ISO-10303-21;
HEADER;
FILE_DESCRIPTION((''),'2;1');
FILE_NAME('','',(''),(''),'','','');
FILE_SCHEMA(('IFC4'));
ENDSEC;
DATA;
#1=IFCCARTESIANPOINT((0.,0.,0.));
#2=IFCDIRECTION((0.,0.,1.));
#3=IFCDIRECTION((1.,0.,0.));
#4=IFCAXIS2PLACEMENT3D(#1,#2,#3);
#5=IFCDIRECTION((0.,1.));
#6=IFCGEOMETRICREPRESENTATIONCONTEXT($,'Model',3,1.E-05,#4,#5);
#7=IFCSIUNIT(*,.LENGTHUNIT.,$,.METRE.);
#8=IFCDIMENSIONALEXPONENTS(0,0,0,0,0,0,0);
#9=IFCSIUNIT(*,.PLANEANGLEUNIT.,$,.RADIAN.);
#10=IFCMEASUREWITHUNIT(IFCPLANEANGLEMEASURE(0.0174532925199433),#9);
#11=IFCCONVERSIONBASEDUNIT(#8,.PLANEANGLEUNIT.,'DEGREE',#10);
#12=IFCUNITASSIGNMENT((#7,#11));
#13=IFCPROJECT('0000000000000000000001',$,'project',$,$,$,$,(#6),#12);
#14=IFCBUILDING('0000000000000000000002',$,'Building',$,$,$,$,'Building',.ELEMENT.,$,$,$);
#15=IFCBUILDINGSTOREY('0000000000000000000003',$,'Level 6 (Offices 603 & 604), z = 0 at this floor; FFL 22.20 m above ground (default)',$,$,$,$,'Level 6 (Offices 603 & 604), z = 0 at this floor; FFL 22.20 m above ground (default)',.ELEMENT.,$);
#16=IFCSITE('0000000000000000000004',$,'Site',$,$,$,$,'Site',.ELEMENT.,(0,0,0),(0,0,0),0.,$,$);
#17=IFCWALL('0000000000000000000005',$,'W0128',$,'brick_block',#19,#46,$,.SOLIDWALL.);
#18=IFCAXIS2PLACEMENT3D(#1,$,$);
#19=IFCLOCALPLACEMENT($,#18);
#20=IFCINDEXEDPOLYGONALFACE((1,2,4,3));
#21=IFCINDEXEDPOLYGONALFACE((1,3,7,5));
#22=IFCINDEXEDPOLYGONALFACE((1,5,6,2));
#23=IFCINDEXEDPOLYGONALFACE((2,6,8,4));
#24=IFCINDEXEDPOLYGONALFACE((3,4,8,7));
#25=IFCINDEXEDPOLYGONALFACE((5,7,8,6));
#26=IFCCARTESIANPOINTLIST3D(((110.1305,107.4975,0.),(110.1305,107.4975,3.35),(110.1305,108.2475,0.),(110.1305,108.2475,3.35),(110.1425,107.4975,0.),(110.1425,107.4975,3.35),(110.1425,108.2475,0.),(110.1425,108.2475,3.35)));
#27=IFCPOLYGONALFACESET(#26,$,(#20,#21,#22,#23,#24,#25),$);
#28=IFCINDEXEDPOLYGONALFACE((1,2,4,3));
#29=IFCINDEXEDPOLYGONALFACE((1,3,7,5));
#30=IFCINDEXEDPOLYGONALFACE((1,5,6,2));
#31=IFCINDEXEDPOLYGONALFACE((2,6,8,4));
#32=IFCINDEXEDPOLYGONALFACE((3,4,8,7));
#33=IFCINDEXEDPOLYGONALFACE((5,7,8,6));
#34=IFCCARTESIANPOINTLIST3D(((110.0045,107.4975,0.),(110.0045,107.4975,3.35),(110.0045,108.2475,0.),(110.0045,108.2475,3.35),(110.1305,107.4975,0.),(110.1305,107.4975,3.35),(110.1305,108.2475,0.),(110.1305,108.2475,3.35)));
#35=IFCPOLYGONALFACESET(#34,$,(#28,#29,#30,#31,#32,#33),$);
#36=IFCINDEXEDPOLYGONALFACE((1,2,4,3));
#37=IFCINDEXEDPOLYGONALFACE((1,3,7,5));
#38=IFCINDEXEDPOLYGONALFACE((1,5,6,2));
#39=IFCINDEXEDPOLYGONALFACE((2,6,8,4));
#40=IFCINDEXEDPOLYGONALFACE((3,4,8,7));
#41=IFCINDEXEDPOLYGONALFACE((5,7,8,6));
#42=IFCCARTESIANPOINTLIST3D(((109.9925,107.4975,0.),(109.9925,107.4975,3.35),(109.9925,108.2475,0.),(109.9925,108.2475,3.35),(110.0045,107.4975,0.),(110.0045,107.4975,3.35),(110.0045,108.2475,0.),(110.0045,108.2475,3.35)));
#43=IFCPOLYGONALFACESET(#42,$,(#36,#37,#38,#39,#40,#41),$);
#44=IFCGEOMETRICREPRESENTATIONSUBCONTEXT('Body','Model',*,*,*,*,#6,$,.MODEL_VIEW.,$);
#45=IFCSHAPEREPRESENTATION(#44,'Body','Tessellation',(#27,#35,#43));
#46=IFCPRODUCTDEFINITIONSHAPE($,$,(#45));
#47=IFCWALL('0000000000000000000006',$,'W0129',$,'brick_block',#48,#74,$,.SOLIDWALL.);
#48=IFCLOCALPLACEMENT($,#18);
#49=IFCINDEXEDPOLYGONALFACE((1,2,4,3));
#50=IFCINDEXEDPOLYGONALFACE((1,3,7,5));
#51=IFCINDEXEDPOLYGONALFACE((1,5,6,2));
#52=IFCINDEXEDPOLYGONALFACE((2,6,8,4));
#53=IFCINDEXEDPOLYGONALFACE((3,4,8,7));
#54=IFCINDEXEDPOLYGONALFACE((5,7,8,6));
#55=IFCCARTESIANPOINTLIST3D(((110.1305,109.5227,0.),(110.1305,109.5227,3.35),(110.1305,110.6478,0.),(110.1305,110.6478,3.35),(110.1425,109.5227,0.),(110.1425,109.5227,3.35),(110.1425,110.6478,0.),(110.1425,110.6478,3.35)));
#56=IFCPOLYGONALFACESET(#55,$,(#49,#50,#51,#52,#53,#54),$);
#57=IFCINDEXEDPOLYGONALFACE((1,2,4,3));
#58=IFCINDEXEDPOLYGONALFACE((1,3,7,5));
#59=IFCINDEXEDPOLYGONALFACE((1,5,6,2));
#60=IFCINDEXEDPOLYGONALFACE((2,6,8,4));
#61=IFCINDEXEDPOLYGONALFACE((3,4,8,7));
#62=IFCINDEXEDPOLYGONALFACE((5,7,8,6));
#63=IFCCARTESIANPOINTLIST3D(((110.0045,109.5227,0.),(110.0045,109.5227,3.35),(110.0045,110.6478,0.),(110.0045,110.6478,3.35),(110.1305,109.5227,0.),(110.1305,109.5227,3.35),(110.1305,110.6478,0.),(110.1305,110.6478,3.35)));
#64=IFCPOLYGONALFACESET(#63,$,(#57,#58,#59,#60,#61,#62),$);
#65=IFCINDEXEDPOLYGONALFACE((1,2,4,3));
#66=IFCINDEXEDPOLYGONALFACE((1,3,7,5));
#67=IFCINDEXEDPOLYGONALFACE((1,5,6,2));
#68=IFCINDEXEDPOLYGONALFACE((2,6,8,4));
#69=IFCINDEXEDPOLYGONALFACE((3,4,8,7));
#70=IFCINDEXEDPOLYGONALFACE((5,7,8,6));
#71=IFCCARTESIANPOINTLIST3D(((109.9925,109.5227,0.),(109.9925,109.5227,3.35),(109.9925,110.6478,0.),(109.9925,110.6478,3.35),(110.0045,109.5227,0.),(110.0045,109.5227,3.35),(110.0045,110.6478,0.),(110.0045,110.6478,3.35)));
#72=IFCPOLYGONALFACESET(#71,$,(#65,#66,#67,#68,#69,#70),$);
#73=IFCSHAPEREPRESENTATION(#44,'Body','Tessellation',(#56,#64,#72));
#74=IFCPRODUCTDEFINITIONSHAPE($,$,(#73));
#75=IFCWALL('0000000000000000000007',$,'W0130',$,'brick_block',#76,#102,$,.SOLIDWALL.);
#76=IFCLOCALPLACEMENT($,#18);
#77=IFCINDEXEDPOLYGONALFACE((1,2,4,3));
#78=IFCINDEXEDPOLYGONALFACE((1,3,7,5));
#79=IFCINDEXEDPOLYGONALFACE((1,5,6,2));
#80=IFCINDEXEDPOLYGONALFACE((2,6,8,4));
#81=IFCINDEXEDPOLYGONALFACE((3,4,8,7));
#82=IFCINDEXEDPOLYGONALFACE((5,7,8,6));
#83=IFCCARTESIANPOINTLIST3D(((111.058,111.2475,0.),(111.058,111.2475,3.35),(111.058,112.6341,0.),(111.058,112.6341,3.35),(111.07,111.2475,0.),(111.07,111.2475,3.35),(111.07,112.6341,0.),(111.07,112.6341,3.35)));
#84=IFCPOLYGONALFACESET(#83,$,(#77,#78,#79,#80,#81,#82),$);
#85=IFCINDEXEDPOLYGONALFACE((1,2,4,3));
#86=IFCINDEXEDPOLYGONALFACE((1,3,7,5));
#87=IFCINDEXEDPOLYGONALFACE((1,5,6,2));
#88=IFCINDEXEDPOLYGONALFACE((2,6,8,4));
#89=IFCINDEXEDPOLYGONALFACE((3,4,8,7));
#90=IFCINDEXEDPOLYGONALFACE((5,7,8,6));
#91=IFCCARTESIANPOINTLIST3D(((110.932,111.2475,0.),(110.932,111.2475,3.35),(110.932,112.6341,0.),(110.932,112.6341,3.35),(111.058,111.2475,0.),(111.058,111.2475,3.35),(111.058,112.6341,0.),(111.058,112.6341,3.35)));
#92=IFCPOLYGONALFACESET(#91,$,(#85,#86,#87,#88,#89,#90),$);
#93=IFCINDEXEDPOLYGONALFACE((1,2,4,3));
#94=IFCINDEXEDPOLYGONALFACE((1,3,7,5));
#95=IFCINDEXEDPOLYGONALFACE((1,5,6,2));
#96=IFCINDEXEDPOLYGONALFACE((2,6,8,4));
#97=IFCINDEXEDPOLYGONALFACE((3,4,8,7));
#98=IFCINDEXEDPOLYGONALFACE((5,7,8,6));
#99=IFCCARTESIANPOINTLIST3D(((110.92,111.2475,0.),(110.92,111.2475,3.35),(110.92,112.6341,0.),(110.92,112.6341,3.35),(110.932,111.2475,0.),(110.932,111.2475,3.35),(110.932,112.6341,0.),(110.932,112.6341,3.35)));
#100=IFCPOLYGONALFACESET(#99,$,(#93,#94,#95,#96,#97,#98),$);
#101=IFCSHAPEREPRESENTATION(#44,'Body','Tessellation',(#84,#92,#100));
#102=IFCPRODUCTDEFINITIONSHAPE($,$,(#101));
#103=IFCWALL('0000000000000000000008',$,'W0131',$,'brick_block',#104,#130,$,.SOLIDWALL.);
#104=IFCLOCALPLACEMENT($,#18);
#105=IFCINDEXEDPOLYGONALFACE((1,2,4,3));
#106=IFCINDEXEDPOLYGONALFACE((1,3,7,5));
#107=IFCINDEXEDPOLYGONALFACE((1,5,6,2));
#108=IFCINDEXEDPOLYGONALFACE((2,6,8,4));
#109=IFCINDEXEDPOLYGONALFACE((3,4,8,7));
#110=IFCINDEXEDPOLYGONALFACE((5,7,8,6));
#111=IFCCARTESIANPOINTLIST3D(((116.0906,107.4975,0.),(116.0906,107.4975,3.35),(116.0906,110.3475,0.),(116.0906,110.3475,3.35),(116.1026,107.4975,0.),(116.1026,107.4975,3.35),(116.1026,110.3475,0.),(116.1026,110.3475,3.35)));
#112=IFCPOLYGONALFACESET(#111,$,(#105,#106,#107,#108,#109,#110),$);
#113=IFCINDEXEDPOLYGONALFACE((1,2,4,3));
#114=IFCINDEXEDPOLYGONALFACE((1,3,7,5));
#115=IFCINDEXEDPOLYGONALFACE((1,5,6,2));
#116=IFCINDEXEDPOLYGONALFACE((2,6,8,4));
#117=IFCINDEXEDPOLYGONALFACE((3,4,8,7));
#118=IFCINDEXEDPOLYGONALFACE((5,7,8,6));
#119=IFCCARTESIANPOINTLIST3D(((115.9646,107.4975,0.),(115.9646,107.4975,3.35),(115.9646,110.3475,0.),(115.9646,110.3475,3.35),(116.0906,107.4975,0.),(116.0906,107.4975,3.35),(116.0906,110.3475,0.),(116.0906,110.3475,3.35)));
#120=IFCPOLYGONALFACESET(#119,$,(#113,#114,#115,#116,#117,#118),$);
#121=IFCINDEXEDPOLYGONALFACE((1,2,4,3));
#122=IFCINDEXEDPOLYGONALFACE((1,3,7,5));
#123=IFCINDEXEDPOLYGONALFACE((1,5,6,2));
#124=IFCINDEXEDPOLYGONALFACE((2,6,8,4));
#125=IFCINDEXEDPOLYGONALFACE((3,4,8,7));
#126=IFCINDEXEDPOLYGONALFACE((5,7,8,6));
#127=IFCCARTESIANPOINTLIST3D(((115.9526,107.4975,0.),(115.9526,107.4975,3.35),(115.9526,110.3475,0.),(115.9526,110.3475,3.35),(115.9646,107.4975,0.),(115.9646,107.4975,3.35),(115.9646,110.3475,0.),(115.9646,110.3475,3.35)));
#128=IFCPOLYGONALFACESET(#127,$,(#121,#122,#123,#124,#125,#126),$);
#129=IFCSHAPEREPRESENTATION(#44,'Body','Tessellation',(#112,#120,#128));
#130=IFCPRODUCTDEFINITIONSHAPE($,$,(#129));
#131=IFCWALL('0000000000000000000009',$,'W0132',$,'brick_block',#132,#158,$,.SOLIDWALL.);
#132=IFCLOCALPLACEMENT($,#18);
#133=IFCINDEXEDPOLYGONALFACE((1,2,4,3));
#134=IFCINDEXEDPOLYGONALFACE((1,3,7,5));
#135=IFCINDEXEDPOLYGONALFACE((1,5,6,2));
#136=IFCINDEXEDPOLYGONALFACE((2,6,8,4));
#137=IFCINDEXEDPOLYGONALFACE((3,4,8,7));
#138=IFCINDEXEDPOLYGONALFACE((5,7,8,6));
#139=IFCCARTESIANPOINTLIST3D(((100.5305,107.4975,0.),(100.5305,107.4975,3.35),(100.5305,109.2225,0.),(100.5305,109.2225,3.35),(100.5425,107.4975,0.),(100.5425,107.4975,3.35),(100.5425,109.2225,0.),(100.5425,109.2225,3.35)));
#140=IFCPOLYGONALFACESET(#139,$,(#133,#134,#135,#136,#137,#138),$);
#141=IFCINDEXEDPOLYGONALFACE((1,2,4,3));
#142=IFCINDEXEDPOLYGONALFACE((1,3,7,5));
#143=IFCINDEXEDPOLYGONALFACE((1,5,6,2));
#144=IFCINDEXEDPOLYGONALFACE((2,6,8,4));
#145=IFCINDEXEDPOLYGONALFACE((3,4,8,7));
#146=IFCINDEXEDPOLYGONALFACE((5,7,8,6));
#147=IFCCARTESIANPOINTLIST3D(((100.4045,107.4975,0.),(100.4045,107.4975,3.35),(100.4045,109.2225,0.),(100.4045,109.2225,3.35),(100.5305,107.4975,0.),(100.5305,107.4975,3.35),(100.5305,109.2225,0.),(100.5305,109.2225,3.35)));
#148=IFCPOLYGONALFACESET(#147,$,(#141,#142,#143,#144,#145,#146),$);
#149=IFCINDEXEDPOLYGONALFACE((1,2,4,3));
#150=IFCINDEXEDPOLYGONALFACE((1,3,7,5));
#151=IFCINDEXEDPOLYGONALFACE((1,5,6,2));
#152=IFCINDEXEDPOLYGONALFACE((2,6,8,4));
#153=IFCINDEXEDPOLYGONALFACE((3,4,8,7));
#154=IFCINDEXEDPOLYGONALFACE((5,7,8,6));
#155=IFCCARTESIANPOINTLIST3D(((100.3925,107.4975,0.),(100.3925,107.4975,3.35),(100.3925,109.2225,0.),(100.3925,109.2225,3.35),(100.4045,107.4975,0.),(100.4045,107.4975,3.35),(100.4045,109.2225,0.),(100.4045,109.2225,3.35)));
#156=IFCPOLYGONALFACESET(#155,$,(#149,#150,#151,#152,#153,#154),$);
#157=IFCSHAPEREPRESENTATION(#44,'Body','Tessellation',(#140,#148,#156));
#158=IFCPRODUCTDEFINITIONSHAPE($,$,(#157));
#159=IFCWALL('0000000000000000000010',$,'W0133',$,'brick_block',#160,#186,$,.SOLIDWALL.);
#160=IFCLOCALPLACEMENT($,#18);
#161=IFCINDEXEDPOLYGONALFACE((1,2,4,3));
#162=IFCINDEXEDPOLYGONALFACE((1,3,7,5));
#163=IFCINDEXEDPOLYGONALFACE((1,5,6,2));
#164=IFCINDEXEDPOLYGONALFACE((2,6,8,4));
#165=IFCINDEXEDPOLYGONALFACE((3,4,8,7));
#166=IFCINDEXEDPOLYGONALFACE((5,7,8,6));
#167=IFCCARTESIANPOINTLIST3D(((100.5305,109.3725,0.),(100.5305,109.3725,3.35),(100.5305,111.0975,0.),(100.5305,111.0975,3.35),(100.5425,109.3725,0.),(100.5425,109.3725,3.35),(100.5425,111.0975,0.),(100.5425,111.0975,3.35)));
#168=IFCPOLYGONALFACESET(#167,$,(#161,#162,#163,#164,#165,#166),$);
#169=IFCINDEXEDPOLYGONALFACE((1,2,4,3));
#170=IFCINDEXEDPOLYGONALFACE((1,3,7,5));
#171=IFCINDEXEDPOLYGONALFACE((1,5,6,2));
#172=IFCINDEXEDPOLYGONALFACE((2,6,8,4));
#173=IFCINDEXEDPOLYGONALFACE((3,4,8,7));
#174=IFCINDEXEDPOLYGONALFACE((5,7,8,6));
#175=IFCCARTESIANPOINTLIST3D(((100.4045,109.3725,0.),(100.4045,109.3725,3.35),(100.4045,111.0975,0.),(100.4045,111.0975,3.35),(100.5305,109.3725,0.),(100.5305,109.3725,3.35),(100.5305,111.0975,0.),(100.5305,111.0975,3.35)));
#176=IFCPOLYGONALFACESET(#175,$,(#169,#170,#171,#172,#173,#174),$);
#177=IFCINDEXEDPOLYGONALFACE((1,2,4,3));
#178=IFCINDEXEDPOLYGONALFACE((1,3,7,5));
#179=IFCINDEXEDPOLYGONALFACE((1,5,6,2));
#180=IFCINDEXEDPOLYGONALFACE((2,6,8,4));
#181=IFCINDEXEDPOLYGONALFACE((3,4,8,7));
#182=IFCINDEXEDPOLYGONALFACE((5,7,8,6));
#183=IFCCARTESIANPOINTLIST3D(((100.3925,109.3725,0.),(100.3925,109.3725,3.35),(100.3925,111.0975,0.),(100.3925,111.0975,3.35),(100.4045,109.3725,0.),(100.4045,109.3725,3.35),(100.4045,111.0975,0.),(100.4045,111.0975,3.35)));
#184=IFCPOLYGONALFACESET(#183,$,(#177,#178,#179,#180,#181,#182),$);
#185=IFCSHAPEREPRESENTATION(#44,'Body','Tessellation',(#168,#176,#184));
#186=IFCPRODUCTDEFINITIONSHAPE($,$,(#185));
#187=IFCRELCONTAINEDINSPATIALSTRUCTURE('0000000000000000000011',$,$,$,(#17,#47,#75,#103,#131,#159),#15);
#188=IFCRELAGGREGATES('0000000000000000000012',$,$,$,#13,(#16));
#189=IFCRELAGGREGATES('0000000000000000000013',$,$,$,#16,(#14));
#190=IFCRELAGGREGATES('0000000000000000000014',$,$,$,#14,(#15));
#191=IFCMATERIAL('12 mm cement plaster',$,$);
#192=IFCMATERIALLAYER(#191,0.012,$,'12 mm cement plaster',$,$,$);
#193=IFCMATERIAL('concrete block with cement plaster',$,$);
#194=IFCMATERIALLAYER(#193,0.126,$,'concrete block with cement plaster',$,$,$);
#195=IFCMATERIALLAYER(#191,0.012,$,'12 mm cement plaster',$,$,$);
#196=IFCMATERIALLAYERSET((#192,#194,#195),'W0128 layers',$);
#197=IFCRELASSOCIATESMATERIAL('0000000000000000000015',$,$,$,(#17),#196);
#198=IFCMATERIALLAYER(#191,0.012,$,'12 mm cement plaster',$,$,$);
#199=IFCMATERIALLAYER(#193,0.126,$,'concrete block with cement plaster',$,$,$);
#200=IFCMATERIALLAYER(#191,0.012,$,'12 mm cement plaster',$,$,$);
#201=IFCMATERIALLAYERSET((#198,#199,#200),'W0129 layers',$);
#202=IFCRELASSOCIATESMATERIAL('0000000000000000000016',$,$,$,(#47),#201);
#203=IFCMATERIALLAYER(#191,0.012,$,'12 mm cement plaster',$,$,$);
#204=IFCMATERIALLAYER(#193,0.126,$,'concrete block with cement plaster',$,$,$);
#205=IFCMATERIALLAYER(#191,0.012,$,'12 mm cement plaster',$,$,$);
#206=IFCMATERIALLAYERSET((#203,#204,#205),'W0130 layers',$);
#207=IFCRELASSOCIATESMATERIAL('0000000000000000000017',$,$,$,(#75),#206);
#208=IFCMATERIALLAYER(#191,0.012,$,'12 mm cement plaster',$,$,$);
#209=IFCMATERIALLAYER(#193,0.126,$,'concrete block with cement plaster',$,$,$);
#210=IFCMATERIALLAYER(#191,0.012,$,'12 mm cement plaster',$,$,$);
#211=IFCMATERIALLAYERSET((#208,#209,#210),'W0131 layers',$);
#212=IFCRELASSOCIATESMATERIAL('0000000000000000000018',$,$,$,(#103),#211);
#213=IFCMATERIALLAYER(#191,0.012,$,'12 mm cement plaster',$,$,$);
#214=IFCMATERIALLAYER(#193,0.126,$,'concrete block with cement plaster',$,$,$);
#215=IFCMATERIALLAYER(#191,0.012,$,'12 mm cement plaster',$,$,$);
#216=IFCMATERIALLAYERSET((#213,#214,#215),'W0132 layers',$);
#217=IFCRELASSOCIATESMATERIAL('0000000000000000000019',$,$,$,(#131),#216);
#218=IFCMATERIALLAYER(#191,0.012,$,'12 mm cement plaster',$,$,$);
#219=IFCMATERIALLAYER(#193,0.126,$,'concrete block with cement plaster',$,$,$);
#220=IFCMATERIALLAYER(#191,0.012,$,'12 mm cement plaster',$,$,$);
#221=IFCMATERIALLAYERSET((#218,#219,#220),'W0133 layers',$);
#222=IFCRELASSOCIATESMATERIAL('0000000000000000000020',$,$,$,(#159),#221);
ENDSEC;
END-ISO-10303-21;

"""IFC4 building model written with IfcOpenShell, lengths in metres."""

from ifc_helpers import new_model, entity, si_unit, converted_unit, direction, frame, frame_2d, origin_with_axes, place, context, subcontext, project, spatial, rectangle, extrude, material, layer, layer_set, layer_usage, element, save


model = new_model("IFC4")

# Units and contexts
model_context = context("Model", 3, precision=1e-05, world=origin_with_axes(), true_north=direction((0.0, 1.0)))
body_context = subcontext(model_context, "Body", "Model", "MODEL_VIEW")
ifc_project = project(units=[si_unit("LENGTHUNIT", "METRE"), converted_unit("PLANEANGLEUNIT", "DEGREE", entity("IfcPlaneAngleMeasure", 0.0174532925199433), si_unit("PLANEANGLEUNIT", "RADIAN"), dimensions=[0, 0, 0, 0, 0, 0, 0])], contexts=[model_context])

# Site, building, storey
site = spatial("IfcSite", under=ifc_project, Name="Site", LongName="Site", CompositionType="ELEMENT", RefLatitude=(0, 0, 0), RefLongitude=(0, 0, 0), RefElevation=0.0)
building = spatial("IfcBuilding", under=site, Name="Building", LongName="Building", CompositionType="ELEMENT")
storey = spatial("IfcBuildingStorey", under=building, Name="Level 6 (Offices 603 & 604), z = 0 at this floor; FFL 22.20 m above ground (default)", LongName="Level 6 (Offices 603 & 604), z = 0 at this floor; FFL 22.20 m above ground (default)", CompositionType="ELEMENT")

# Walls
ifc_material_1 = material(Name="12 mm cement plaster")
ifc_layer_1 = layer(ifc_material_1, 0.012, Name="12 mm cement plaster")
ifc_material_2 = material(Name="concrete block with cement plaster")
ifc_layer_2 = layer(ifc_material_2, 0.126, Name="concrete block with cement plaster")
ifc_layer_3 = layer(ifc_material_1, 0.012, Name="12 mm cement plaster")
ifc_layer_set_1 = layer_set([ifc_layer_1, ifc_layer_2, ifc_layer_3], Name="W0128 layers")
ifc_layer_usage_1 = layer_usage(ifc_layer_set_1, "AXIS2", "POSITIVE", -0.075)
placement = place(None, origin_with_axes())
element("IfcWall", 1, at=placement, inside=storey, material=ifc_layer_usage_1, Name="W0128", ObjectType="brick_block", PredefinedType="SOLIDWALL", context=body_context, shape_type="SweptSolid", body=[
    extrude(rectangle(XDim=0.75, YDim=0.012, at=frame_2d((0.0, 0.0), x_axis=(0.0, 1.0))), frame((110.1365, 107.8725, 0.0), z_axis=(0.0, 0.0, 1.0), x_axis=(1.0, 0.0, 0.0)), (0.0, 0.0, 1.0), 3.35),
    extrude(rectangle(XDim=0.75, YDim=0.126, at=frame_2d((-0.069, 0.0), x_axis=(0.0, 1.0))), frame((110.1365, 107.8725, 0.0), z_axis=(0.0, 0.0, 1.0), x_axis=(1.0, 0.0, 0.0)), (0.0, 0.0, 1.0), 3.35),
    extrude(rectangle(XDim=0.75, YDim=0.012, at=frame_2d((-0.138, 0.0), x_axis=(0.0, 1.0))), frame((110.1365, 107.8725, 0.0), z_axis=(0.0, 0.0, 1.0), x_axis=(1.0, 0.0, 0.0)), (0.0, 0.0, 1.0), 3.35),
])
ifc_layer_4 = layer(ifc_material_1, 0.012, Name="12 mm cement plaster")
ifc_layer_5 = layer(ifc_material_2, 0.126, Name="concrete block with cement plaster")
ifc_layer_6 = layer(ifc_material_1, 0.012, Name="12 mm cement plaster")
ifc_layer_set_2 = layer_set([ifc_layer_4, ifc_layer_5, ifc_layer_6], Name="W0129 layers")
ifc_layer_usage_2 = layer_usage(ifc_layer_set_2, "AXIS2", "POSITIVE", -0.075)
element("IfcWall", 2, at=placement, inside=storey, material=ifc_layer_usage_2, Name="W0129", ObjectType="brick_block", PredefinedType="SOLIDWALL", context=body_context, shape_type="SweptSolid", body=[
    extrude(rectangle(XDim=1.1251, YDim=0.012, at=frame_2d((0.0, 0.0), x_axis=(0.0, 1.0))), frame((110.1365, 110.0853, 0.0), z_axis=(0.0, 0.0, 1.0), x_axis=(1.0, 0.0, 0.0)), (0.0, 0.0, 1.0), 3.35),
    extrude(rectangle(XDim=1.1251, YDim=0.126, at=frame_2d((-0.069, 0.0), x_axis=(0.0, 1.0))), frame((110.1365, 110.0853, 0.0), z_axis=(0.0, 0.0, 1.0), x_axis=(1.0, 0.0, 0.0)), (0.0, 0.0, 1.0), 3.35),
    extrude(rectangle(XDim=1.1251, YDim=0.012, at=frame_2d((-0.138, 0.0), x_axis=(0.0, 1.0))), frame((110.1365, 110.0853, 0.0), z_axis=(0.0, 0.0, 1.0), x_axis=(1.0, 0.0, 0.0)), (0.0, 0.0, 1.0), 3.35),
])
ifc_layer_7 = layer(ifc_material_1, 0.012, Name="12 mm cement plaster")
ifc_layer_8 = layer(ifc_material_2, 0.126, Name="concrete block with cement plaster")
ifc_layer_9 = layer(ifc_material_1, 0.012, Name="12 mm cement plaster")
ifc_layer_set_3 = layer_set([ifc_layer_7, ifc_layer_8, ifc_layer_9], Name="W0130 layers")
ifc_layer_usage_3 = layer_usage(ifc_layer_set_3, "AXIS2", "POSITIVE", -0.075)
element("IfcWall", 3, at=placement, inside=storey, material=ifc_layer_usage_3, Name="W0130", ObjectType="brick_block", PredefinedType="SOLIDWALL", context=body_context, shape_type="SweptSolid", body=[
    extrude(rectangle(XDim=1.3866, YDim=0.012, at=frame_2d((0.0, 0.0), x_axis=(0.0, 1.0))), frame((111.064, 111.9408, 0.0), z_axis=(0.0, 0.0, 1.0), x_axis=(1.0, 0.0, 0.0)), (0.0, 0.0, 1.0), 3.35),
    extrude(rectangle(XDim=1.3866, YDim=0.126, at=frame_2d((-0.069, 0.0), x_axis=(0.0, 1.0))), frame((111.064, 111.9408, 0.0), z_axis=(0.0, 0.0, 1.0), x_axis=(1.0, 0.0, 0.0)), (0.0, 0.0, 1.0), 3.35),
    extrude(rectangle(XDim=1.3866, YDim=0.012, at=frame_2d((-0.138, 0.0), x_axis=(0.0, 1.0))), frame((111.064, 111.9408, 0.0), z_axis=(0.0, 0.0, 1.0), x_axis=(1.0, 0.0, 0.0)), (0.0, 0.0, 1.0), 3.35),
])
ifc_layer_10 = layer(ifc_material_1, 0.012, Name="12 mm cement plaster")
ifc_layer_11 = layer(ifc_material_2, 0.126, Name="concrete block with cement plaster")
ifc_layer_12 = layer(ifc_material_1, 0.012, Name="12 mm cement plaster")
ifc_layer_set_4 = layer_set([ifc_layer_10, ifc_layer_11, ifc_layer_12], Name="W0131 layers")
ifc_layer_usage_4 = layer_usage(ifc_layer_set_4, "AXIS2", "POSITIVE", -0.075)
element("IfcWall", 4, at=placement, inside=storey, material=ifc_layer_usage_4, Name="W0131", ObjectType="brick_block", PredefinedType="SOLIDWALL", context=body_context, shape_type="SweptSolid", body=[
    extrude(rectangle(XDim=2.85, YDim=0.012, at=frame_2d((0.0, 0.0), x_axis=(0.0, 1.0))), frame((116.0966, 108.9225, 0.0), z_axis=(0.0, 0.0, 1.0), x_axis=(1.0, 0.0, 0.0)), (0.0, 0.0, 1.0), 3.35),
    extrude(rectangle(XDim=2.85, YDim=0.126, at=frame_2d((-0.069, 0.0), x_axis=(0.0, 1.0))), frame((116.0966, 108.9225, 0.0), z_axis=(0.0, 0.0, 1.0), x_axis=(1.0, 0.0, 0.0)), (0.0, 0.0, 1.0), 3.35),
    extrude(rectangle(XDim=2.85, YDim=0.012, at=frame_2d((-0.138, 0.0), x_axis=(0.0, 1.0))), frame((116.0966, 108.9225, 0.0), z_axis=(0.0, 0.0, 1.0), x_axis=(1.0, 0.0, 0.0)), (0.0, 0.0, 1.0), 3.35),
])
ifc_layer_13 = layer(ifc_material_1, 0.012, Name="12 mm cement plaster")
ifc_layer_14 = layer(ifc_material_2, 0.126, Name="concrete block with cement plaster")
ifc_layer_15 = layer(ifc_material_1, 0.012, Name="12 mm cement plaster")
ifc_layer_set_5 = layer_set([ifc_layer_13, ifc_layer_14, ifc_layer_15], Name="W0132 layers")
ifc_layer_usage_5 = layer_usage(ifc_layer_set_5, "AXIS2", "POSITIVE", -0.075)
element("IfcWall", 5, at=placement, inside=storey, material=ifc_layer_usage_5, Name="W0132", ObjectType="brick_block", PredefinedType="SOLIDWALL", context=body_context, shape_type="SweptSolid", body=[
    extrude(rectangle(XDim=1.725, YDim=0.012, at=frame_2d((0.0, 0.0), x_axis=(0.0, 1.0))), frame((100.5365, 108.36, 0.0), z_axis=(0.0, 0.0, 1.0), x_axis=(1.0, 0.0, 0.0)), (0.0, 0.0, 1.0), 3.35),
    extrude(rectangle(XDim=1.725, YDim=0.126, at=frame_2d((-0.069, 0.0), x_axis=(0.0, 1.0))), frame((100.5365, 108.36, 0.0), z_axis=(0.0, 0.0, 1.0), x_axis=(1.0, 0.0, 0.0)), (0.0, 0.0, 1.0), 3.35),
    extrude(rectangle(XDim=1.725, YDim=0.012, at=frame_2d((-0.138, 0.0), x_axis=(0.0, 1.0))), frame((100.5365, 108.36, 0.0), z_axis=(0.0, 0.0, 1.0), x_axis=(1.0, 0.0, 0.0)), (0.0, 0.0, 1.0), 3.35),
])
ifc_layer_16 = layer(ifc_material_1, 0.012, Name="12 mm cement plaster")
ifc_layer_17 = layer(ifc_material_2, 0.126, Name="concrete block with cement plaster")
ifc_layer_18 = layer(ifc_material_1, 0.012, Name="12 mm cement plaster")
ifc_layer_set_6 = layer_set([ifc_layer_16, ifc_layer_17, ifc_layer_18], Name="W0133 layers")
ifc_layer_usage_6 = layer_usage(ifc_layer_set_6, "AXIS2", "POSITIVE", -0.075)
element("IfcWall", 6, at=placement, inside=storey, material=ifc_layer_usage_6, Name="W0133", ObjectType="brick_block", PredefinedType="SOLIDWALL", context=body_context, shape_type="SweptSolid", body=[
    extrude(rectangle(XDim=1.725, YDim=0.012, at=frame_2d((0.0, 0.0), x_axis=(0.0, 1.0))), frame((100.5365, 110.235, 0.0), z_axis=(0.0, 0.0, 1.0), x_axis=(1.0, 0.0, 0.0)), (0.0, 0.0, 1.0), 3.35),
    extrude(rectangle(XDim=1.725, YDim=0.126, at=frame_2d((-0.069, 0.0), x_axis=(0.0, 1.0))), frame((100.5365, 110.235, 0.0), z_axis=(0.0, 0.0, 1.0), x_axis=(1.0, 0.0, 0.0)), (0.0, 0.0, 1.0), 3.35),
    extrude(rectangle(XDim=1.725, YDim=0.012, at=frame_2d((-0.138, 0.0), x_axis=(0.0, 1.0))), frame((100.5365, 110.235, 0.0), z_axis=(0.0, 0.0, 1.0), x_axis=(1.0, 0.0, 0.0)), (0.0, 0.0, 1.0), 3.35),
])

save(model, "model.ifc")
